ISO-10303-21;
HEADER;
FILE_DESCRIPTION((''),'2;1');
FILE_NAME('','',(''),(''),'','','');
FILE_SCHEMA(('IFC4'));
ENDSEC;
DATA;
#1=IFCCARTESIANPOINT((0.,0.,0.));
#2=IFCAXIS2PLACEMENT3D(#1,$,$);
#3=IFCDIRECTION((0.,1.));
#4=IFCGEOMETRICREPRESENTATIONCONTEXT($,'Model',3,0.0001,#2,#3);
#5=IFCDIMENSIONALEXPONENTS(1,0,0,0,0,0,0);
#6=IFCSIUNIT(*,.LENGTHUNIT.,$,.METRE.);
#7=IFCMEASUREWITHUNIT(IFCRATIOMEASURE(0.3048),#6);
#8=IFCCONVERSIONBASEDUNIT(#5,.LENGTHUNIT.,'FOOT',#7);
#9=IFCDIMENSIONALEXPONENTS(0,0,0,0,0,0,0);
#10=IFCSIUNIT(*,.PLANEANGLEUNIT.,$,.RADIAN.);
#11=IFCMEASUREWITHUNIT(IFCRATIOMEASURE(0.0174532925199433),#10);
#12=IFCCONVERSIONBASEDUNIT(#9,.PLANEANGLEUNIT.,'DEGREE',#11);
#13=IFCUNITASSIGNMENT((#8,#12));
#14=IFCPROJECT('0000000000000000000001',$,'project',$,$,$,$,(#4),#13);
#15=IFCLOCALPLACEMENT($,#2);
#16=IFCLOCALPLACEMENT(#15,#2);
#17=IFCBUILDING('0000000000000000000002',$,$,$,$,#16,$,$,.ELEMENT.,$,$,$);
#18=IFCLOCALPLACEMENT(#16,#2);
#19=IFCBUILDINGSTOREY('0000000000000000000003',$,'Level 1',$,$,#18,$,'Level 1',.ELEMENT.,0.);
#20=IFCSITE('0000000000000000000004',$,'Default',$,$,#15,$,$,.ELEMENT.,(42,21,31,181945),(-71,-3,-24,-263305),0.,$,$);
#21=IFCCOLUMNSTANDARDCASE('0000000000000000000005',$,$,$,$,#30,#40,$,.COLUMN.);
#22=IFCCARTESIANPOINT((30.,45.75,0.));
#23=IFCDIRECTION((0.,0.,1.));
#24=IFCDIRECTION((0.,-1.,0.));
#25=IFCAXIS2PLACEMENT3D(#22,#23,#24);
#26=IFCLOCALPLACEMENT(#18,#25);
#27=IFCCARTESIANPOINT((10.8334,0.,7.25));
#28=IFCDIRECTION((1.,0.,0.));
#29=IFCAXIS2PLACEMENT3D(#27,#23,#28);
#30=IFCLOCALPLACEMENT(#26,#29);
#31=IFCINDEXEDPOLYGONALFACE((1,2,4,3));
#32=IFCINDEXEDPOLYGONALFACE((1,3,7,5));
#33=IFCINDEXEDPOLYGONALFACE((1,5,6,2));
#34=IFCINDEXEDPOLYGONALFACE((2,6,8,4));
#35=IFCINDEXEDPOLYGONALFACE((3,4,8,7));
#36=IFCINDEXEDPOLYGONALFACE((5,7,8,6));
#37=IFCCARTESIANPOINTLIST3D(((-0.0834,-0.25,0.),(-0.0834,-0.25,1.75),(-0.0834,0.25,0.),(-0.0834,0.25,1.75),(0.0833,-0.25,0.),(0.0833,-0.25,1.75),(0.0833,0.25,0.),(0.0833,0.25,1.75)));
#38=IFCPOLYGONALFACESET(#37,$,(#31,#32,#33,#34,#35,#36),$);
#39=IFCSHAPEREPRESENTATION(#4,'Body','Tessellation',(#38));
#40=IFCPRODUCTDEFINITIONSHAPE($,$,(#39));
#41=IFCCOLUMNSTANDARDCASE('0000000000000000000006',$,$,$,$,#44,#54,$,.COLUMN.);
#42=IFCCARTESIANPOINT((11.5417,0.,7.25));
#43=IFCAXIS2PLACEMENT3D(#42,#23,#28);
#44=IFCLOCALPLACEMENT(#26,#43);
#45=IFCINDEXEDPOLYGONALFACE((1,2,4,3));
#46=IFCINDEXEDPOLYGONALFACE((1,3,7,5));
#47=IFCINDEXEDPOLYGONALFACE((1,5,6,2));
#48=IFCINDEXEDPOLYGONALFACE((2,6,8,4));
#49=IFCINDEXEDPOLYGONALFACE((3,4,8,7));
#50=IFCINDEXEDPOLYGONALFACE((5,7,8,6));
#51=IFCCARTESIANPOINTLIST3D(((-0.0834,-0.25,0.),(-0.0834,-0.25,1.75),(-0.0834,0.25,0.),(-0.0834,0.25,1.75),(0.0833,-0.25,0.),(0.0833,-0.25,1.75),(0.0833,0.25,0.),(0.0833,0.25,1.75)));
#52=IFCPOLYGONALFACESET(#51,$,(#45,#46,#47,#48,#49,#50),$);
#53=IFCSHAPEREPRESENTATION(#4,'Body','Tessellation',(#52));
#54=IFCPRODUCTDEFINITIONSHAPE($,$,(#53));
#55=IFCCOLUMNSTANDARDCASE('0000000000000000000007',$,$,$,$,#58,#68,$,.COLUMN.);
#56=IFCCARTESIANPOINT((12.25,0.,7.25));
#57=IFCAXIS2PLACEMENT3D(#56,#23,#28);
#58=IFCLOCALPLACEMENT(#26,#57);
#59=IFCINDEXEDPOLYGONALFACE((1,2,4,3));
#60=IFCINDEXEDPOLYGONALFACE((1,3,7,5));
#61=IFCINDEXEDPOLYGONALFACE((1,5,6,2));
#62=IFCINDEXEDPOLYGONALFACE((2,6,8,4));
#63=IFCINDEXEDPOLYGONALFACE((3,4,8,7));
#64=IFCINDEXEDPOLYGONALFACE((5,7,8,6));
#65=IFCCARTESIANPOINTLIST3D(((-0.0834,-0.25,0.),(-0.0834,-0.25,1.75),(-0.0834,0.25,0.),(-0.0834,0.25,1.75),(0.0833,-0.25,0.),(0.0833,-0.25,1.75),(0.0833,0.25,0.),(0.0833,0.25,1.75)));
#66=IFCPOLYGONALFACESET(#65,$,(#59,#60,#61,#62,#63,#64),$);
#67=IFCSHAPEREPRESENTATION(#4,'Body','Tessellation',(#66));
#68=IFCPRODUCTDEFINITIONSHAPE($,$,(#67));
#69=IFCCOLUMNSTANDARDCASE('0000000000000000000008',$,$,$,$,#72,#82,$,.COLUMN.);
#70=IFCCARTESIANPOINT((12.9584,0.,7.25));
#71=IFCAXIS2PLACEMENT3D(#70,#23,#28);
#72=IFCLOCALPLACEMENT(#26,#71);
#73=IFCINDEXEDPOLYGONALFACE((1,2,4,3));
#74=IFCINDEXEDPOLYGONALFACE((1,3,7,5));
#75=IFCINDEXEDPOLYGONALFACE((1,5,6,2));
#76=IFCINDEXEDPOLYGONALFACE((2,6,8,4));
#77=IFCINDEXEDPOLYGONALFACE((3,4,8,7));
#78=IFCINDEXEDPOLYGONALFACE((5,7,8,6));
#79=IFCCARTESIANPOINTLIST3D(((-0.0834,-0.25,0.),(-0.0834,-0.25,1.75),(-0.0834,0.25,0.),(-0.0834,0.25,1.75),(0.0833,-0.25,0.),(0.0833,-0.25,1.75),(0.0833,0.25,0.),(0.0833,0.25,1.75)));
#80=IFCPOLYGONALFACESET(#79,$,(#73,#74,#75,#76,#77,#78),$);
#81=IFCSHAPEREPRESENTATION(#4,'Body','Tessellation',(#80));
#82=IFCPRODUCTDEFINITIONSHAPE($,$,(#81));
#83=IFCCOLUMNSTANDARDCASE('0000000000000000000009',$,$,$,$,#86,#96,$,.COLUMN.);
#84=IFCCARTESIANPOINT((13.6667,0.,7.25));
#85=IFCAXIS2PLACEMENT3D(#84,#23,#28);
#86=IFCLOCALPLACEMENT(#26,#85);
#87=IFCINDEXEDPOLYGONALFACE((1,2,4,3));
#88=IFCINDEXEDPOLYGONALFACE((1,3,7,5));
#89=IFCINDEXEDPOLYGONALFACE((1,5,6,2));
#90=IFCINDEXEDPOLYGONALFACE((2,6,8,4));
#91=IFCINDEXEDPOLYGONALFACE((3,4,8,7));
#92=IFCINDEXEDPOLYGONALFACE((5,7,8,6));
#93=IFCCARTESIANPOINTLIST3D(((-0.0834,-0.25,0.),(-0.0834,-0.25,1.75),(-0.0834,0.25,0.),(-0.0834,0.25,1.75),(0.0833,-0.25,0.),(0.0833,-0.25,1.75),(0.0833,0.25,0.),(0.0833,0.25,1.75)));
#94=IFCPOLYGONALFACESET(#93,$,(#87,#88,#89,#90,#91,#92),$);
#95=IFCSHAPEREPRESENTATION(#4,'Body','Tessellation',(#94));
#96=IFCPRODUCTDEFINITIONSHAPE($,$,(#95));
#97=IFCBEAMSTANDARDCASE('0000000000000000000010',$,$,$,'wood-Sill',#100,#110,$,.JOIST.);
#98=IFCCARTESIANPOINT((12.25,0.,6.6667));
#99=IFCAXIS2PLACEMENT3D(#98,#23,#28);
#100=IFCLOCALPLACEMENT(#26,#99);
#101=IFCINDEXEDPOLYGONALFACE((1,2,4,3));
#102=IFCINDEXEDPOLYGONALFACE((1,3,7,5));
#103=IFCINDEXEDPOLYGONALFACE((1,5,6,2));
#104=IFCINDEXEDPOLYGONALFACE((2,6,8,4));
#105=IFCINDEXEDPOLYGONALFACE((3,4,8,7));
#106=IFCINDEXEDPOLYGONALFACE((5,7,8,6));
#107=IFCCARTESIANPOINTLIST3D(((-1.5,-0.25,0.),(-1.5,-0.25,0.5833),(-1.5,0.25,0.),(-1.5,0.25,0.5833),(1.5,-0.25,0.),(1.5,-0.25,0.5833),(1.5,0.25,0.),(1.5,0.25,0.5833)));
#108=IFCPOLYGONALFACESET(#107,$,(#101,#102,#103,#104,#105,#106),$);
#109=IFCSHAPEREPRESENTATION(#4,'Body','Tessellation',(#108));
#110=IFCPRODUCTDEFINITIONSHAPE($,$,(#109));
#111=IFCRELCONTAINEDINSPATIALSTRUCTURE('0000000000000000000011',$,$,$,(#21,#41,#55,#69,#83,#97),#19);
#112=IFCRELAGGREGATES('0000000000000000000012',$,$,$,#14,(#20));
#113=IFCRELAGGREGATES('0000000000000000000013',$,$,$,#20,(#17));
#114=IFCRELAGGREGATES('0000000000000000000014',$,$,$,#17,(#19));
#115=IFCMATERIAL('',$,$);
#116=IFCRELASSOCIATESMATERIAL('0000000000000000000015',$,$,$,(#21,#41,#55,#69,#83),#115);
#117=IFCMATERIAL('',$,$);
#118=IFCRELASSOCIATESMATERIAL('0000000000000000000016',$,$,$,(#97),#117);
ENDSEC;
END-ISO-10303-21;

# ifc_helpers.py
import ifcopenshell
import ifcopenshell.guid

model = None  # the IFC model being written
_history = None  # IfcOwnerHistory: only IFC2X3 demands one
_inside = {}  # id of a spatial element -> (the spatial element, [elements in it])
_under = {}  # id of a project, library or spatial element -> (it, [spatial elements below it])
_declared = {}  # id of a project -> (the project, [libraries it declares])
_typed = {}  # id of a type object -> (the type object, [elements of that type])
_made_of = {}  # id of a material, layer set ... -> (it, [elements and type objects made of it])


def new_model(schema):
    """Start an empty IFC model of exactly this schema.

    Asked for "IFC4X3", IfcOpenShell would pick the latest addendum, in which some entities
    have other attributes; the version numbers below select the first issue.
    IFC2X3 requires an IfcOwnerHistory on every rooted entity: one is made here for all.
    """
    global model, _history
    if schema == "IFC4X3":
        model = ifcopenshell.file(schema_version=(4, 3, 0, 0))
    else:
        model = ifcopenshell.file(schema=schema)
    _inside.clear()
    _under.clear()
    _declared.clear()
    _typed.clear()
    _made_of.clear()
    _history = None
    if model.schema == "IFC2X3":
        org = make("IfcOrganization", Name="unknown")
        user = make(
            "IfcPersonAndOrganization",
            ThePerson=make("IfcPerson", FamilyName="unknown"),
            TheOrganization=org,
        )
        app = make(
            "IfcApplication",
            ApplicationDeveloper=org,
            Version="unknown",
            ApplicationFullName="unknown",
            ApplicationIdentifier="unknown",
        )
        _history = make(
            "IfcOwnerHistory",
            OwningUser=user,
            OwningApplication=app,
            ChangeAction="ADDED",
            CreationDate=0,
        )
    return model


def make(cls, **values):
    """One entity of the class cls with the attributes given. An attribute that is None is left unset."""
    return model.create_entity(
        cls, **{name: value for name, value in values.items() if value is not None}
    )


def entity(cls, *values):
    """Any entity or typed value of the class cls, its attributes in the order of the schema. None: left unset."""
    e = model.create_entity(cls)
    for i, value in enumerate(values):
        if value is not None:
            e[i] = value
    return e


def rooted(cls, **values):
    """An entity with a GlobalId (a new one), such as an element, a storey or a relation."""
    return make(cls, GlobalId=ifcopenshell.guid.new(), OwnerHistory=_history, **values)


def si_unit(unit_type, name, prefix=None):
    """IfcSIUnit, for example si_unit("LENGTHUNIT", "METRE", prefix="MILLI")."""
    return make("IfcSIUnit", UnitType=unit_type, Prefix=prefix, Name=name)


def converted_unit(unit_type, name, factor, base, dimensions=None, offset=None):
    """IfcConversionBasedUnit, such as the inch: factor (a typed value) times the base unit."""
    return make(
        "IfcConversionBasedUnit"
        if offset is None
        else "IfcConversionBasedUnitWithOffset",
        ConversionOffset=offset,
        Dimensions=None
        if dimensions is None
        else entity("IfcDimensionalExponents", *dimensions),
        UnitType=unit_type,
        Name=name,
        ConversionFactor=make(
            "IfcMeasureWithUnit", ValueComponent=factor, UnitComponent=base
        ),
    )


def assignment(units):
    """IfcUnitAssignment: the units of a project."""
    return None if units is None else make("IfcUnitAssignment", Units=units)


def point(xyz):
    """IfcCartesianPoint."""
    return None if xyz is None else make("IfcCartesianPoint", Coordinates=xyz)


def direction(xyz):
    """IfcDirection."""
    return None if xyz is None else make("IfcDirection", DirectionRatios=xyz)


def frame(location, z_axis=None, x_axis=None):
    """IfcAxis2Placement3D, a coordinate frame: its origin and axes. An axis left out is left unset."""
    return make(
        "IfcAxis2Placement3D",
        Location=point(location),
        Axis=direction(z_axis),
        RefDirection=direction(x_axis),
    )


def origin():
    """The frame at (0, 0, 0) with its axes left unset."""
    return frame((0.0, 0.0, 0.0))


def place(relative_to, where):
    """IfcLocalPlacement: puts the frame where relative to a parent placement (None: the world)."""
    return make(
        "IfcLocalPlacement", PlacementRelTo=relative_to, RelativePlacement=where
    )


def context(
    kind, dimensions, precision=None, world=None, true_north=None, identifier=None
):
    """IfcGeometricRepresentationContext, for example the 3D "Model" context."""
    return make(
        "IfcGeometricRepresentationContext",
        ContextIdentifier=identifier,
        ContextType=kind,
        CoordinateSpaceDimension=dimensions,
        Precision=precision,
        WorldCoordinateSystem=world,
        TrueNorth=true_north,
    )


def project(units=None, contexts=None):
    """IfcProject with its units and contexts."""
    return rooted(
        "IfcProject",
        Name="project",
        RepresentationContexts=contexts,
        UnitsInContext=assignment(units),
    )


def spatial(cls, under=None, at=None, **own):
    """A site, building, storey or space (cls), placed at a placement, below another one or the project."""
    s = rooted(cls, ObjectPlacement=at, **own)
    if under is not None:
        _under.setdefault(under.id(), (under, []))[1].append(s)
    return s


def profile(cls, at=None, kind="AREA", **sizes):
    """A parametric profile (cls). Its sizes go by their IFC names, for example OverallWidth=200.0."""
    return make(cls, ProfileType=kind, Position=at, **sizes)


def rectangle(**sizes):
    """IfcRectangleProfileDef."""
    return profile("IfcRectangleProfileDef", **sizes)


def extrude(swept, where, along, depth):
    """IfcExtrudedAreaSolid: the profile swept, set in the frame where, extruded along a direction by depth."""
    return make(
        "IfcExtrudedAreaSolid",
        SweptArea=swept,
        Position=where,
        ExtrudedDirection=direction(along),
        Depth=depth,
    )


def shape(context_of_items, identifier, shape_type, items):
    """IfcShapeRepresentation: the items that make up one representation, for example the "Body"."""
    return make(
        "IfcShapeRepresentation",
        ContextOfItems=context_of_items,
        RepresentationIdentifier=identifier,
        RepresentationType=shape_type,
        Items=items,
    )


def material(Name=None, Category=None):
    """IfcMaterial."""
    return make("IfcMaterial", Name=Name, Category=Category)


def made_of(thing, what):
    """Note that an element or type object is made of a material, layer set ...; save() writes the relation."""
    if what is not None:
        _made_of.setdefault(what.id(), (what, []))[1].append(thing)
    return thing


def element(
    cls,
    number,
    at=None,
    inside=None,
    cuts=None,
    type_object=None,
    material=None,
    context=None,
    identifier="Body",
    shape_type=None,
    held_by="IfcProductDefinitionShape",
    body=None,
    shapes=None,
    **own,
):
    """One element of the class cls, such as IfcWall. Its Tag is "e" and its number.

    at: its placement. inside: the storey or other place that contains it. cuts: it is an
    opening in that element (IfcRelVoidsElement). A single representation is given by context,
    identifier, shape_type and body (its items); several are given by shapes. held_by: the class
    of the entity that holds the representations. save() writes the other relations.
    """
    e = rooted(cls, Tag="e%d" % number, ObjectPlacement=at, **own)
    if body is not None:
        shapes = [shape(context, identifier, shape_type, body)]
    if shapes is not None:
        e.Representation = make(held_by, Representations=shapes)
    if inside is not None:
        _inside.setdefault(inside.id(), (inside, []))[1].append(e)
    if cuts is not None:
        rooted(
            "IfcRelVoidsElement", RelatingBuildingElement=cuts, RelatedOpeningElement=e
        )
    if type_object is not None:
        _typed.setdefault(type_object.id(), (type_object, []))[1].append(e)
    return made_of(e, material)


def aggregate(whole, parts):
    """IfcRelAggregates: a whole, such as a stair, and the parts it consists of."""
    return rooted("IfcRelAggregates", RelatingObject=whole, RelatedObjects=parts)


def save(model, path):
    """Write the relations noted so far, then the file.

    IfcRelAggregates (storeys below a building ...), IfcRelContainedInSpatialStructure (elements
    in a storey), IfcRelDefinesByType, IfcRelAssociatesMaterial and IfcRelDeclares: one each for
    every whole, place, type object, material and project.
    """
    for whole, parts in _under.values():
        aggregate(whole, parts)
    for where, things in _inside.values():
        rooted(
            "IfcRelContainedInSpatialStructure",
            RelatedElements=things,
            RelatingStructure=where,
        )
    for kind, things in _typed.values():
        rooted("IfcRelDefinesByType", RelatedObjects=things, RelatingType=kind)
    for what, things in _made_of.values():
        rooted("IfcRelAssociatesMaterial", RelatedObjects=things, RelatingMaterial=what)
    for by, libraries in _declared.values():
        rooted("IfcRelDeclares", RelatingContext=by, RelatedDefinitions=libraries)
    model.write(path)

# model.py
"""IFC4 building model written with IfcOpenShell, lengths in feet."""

from ifc_helpers import new_model, entity, si_unit, converted_unit, direction, frame, origin, place, context, project, spatial, rectangle, extrude, material, element, save


model = new_model("IFC4")

# Units and contexts
model_context = context("Model", 3, precision=0.0001, world=origin(), true_north=direction((0.0, 1.0)))
ifc_project = project(units=[converted_unit("LENGTHUNIT", "FOOT", entity("IfcRatioMeasure", 0.3048), si_unit("LENGTHUNIT", "METRE"), dimensions=[1, 0, 0, 0, 0, 0, 0]), converted_unit("PLANEANGLEUNIT", "DEGREE", entity("IfcRatioMeasure", 0.0174532925199433), si_unit("PLANEANGLEUNIT", "RADIAN"), dimensions=[0, 0, 0, 0, 0, 0, 0])], contexts=[model_context])

# Site, building, storey
site_placement = place(None, origin())
site = spatial("IfcSite", under=ifc_project, at=site_placement, Name="Default", CompositionType="ELEMENT", RefLatitude=(42, 21, 31, 181945), RefLongitude=(-71, -3, -24, -263305), RefElevation=0.0)
building_placement = place(site_placement, origin())
building = spatial("IfcBuilding", under=site, at=building_placement, CompositionType="ELEMENT")
storey_placement = place(building_placement, origin())
storey = spatial("IfcBuildingStorey", under=building, at=storey_placement, Name="Level 1", LongName="Level 1", CompositionType="ELEMENT", Elevation=0.0)

# Columns
placement_1 = place(storey_placement, frame((30.0, 45.75, 0.0), z_axis=(0.0, 0.0, 1.0), x_axis=(0.0, -1.0, 0.0)))
ifc_material_1 = material(Name="")
for number, where, z_axis, x_axis in (
    (1, (10.8334, 0.0, 7.25), (0.0, 0.0, 1.0), (1.0, 0.0, 0.0)),
    (2, (11.5417, 0.0, 7.25), (0.0, 0.0, 1.0), (1.0, 0.0, 0.0)),
    (3, (12.25, 0.0, 7.25), (0.0, 0.0, 1.0), (1.0, 0.0, 0.0)),
    (4, (12.9584, 0.0, 7.25), (0.0, 0.0, 1.0), (1.0, 0.0, 0.0)),
    (5, (13.6667, 0.0, 7.25), (0.0, 0.0, 1.0), (1.0, 0.0, 0.0)),
):
    element("IfcColumnStandardCase", number, at=place(placement_1, frame(where, z_axis=z_axis, x_axis=x_axis)), inside=storey, material=ifc_material_1, PredefinedType="COLUMN", context=model_context, shape_type="SweptSolid", body=[
        extrude(rectangle(XDim=0.1667, YDim=0.5), origin(), (0.0, 0.0, 1.0), 1.75),
    ])

# Beam
ifc_material_2 = material(Name="")
for number, where, z_axis, x_axis in (
    (6, (12.25, 0.0, 6.6667), (0.0, 0.0, 1.0), (1.0, 0.0, 0.0)),
):
    element("IfcBeamStandardCase", number, at=place(placement_1, frame(where, z_axis=z_axis, x_axis=x_axis)), inside=storey, material=ifc_material_2, ObjectType="wood-Sill", PredefinedType="JOIST", context=model_context, shape_type="SweptSolid", body=[
        extrude(rectangle(XDim=3.0, YDim=0.5), origin(), (0.0, 0.0, 1.0), 0.5833),
    ])

save(model, "model.ifc")
